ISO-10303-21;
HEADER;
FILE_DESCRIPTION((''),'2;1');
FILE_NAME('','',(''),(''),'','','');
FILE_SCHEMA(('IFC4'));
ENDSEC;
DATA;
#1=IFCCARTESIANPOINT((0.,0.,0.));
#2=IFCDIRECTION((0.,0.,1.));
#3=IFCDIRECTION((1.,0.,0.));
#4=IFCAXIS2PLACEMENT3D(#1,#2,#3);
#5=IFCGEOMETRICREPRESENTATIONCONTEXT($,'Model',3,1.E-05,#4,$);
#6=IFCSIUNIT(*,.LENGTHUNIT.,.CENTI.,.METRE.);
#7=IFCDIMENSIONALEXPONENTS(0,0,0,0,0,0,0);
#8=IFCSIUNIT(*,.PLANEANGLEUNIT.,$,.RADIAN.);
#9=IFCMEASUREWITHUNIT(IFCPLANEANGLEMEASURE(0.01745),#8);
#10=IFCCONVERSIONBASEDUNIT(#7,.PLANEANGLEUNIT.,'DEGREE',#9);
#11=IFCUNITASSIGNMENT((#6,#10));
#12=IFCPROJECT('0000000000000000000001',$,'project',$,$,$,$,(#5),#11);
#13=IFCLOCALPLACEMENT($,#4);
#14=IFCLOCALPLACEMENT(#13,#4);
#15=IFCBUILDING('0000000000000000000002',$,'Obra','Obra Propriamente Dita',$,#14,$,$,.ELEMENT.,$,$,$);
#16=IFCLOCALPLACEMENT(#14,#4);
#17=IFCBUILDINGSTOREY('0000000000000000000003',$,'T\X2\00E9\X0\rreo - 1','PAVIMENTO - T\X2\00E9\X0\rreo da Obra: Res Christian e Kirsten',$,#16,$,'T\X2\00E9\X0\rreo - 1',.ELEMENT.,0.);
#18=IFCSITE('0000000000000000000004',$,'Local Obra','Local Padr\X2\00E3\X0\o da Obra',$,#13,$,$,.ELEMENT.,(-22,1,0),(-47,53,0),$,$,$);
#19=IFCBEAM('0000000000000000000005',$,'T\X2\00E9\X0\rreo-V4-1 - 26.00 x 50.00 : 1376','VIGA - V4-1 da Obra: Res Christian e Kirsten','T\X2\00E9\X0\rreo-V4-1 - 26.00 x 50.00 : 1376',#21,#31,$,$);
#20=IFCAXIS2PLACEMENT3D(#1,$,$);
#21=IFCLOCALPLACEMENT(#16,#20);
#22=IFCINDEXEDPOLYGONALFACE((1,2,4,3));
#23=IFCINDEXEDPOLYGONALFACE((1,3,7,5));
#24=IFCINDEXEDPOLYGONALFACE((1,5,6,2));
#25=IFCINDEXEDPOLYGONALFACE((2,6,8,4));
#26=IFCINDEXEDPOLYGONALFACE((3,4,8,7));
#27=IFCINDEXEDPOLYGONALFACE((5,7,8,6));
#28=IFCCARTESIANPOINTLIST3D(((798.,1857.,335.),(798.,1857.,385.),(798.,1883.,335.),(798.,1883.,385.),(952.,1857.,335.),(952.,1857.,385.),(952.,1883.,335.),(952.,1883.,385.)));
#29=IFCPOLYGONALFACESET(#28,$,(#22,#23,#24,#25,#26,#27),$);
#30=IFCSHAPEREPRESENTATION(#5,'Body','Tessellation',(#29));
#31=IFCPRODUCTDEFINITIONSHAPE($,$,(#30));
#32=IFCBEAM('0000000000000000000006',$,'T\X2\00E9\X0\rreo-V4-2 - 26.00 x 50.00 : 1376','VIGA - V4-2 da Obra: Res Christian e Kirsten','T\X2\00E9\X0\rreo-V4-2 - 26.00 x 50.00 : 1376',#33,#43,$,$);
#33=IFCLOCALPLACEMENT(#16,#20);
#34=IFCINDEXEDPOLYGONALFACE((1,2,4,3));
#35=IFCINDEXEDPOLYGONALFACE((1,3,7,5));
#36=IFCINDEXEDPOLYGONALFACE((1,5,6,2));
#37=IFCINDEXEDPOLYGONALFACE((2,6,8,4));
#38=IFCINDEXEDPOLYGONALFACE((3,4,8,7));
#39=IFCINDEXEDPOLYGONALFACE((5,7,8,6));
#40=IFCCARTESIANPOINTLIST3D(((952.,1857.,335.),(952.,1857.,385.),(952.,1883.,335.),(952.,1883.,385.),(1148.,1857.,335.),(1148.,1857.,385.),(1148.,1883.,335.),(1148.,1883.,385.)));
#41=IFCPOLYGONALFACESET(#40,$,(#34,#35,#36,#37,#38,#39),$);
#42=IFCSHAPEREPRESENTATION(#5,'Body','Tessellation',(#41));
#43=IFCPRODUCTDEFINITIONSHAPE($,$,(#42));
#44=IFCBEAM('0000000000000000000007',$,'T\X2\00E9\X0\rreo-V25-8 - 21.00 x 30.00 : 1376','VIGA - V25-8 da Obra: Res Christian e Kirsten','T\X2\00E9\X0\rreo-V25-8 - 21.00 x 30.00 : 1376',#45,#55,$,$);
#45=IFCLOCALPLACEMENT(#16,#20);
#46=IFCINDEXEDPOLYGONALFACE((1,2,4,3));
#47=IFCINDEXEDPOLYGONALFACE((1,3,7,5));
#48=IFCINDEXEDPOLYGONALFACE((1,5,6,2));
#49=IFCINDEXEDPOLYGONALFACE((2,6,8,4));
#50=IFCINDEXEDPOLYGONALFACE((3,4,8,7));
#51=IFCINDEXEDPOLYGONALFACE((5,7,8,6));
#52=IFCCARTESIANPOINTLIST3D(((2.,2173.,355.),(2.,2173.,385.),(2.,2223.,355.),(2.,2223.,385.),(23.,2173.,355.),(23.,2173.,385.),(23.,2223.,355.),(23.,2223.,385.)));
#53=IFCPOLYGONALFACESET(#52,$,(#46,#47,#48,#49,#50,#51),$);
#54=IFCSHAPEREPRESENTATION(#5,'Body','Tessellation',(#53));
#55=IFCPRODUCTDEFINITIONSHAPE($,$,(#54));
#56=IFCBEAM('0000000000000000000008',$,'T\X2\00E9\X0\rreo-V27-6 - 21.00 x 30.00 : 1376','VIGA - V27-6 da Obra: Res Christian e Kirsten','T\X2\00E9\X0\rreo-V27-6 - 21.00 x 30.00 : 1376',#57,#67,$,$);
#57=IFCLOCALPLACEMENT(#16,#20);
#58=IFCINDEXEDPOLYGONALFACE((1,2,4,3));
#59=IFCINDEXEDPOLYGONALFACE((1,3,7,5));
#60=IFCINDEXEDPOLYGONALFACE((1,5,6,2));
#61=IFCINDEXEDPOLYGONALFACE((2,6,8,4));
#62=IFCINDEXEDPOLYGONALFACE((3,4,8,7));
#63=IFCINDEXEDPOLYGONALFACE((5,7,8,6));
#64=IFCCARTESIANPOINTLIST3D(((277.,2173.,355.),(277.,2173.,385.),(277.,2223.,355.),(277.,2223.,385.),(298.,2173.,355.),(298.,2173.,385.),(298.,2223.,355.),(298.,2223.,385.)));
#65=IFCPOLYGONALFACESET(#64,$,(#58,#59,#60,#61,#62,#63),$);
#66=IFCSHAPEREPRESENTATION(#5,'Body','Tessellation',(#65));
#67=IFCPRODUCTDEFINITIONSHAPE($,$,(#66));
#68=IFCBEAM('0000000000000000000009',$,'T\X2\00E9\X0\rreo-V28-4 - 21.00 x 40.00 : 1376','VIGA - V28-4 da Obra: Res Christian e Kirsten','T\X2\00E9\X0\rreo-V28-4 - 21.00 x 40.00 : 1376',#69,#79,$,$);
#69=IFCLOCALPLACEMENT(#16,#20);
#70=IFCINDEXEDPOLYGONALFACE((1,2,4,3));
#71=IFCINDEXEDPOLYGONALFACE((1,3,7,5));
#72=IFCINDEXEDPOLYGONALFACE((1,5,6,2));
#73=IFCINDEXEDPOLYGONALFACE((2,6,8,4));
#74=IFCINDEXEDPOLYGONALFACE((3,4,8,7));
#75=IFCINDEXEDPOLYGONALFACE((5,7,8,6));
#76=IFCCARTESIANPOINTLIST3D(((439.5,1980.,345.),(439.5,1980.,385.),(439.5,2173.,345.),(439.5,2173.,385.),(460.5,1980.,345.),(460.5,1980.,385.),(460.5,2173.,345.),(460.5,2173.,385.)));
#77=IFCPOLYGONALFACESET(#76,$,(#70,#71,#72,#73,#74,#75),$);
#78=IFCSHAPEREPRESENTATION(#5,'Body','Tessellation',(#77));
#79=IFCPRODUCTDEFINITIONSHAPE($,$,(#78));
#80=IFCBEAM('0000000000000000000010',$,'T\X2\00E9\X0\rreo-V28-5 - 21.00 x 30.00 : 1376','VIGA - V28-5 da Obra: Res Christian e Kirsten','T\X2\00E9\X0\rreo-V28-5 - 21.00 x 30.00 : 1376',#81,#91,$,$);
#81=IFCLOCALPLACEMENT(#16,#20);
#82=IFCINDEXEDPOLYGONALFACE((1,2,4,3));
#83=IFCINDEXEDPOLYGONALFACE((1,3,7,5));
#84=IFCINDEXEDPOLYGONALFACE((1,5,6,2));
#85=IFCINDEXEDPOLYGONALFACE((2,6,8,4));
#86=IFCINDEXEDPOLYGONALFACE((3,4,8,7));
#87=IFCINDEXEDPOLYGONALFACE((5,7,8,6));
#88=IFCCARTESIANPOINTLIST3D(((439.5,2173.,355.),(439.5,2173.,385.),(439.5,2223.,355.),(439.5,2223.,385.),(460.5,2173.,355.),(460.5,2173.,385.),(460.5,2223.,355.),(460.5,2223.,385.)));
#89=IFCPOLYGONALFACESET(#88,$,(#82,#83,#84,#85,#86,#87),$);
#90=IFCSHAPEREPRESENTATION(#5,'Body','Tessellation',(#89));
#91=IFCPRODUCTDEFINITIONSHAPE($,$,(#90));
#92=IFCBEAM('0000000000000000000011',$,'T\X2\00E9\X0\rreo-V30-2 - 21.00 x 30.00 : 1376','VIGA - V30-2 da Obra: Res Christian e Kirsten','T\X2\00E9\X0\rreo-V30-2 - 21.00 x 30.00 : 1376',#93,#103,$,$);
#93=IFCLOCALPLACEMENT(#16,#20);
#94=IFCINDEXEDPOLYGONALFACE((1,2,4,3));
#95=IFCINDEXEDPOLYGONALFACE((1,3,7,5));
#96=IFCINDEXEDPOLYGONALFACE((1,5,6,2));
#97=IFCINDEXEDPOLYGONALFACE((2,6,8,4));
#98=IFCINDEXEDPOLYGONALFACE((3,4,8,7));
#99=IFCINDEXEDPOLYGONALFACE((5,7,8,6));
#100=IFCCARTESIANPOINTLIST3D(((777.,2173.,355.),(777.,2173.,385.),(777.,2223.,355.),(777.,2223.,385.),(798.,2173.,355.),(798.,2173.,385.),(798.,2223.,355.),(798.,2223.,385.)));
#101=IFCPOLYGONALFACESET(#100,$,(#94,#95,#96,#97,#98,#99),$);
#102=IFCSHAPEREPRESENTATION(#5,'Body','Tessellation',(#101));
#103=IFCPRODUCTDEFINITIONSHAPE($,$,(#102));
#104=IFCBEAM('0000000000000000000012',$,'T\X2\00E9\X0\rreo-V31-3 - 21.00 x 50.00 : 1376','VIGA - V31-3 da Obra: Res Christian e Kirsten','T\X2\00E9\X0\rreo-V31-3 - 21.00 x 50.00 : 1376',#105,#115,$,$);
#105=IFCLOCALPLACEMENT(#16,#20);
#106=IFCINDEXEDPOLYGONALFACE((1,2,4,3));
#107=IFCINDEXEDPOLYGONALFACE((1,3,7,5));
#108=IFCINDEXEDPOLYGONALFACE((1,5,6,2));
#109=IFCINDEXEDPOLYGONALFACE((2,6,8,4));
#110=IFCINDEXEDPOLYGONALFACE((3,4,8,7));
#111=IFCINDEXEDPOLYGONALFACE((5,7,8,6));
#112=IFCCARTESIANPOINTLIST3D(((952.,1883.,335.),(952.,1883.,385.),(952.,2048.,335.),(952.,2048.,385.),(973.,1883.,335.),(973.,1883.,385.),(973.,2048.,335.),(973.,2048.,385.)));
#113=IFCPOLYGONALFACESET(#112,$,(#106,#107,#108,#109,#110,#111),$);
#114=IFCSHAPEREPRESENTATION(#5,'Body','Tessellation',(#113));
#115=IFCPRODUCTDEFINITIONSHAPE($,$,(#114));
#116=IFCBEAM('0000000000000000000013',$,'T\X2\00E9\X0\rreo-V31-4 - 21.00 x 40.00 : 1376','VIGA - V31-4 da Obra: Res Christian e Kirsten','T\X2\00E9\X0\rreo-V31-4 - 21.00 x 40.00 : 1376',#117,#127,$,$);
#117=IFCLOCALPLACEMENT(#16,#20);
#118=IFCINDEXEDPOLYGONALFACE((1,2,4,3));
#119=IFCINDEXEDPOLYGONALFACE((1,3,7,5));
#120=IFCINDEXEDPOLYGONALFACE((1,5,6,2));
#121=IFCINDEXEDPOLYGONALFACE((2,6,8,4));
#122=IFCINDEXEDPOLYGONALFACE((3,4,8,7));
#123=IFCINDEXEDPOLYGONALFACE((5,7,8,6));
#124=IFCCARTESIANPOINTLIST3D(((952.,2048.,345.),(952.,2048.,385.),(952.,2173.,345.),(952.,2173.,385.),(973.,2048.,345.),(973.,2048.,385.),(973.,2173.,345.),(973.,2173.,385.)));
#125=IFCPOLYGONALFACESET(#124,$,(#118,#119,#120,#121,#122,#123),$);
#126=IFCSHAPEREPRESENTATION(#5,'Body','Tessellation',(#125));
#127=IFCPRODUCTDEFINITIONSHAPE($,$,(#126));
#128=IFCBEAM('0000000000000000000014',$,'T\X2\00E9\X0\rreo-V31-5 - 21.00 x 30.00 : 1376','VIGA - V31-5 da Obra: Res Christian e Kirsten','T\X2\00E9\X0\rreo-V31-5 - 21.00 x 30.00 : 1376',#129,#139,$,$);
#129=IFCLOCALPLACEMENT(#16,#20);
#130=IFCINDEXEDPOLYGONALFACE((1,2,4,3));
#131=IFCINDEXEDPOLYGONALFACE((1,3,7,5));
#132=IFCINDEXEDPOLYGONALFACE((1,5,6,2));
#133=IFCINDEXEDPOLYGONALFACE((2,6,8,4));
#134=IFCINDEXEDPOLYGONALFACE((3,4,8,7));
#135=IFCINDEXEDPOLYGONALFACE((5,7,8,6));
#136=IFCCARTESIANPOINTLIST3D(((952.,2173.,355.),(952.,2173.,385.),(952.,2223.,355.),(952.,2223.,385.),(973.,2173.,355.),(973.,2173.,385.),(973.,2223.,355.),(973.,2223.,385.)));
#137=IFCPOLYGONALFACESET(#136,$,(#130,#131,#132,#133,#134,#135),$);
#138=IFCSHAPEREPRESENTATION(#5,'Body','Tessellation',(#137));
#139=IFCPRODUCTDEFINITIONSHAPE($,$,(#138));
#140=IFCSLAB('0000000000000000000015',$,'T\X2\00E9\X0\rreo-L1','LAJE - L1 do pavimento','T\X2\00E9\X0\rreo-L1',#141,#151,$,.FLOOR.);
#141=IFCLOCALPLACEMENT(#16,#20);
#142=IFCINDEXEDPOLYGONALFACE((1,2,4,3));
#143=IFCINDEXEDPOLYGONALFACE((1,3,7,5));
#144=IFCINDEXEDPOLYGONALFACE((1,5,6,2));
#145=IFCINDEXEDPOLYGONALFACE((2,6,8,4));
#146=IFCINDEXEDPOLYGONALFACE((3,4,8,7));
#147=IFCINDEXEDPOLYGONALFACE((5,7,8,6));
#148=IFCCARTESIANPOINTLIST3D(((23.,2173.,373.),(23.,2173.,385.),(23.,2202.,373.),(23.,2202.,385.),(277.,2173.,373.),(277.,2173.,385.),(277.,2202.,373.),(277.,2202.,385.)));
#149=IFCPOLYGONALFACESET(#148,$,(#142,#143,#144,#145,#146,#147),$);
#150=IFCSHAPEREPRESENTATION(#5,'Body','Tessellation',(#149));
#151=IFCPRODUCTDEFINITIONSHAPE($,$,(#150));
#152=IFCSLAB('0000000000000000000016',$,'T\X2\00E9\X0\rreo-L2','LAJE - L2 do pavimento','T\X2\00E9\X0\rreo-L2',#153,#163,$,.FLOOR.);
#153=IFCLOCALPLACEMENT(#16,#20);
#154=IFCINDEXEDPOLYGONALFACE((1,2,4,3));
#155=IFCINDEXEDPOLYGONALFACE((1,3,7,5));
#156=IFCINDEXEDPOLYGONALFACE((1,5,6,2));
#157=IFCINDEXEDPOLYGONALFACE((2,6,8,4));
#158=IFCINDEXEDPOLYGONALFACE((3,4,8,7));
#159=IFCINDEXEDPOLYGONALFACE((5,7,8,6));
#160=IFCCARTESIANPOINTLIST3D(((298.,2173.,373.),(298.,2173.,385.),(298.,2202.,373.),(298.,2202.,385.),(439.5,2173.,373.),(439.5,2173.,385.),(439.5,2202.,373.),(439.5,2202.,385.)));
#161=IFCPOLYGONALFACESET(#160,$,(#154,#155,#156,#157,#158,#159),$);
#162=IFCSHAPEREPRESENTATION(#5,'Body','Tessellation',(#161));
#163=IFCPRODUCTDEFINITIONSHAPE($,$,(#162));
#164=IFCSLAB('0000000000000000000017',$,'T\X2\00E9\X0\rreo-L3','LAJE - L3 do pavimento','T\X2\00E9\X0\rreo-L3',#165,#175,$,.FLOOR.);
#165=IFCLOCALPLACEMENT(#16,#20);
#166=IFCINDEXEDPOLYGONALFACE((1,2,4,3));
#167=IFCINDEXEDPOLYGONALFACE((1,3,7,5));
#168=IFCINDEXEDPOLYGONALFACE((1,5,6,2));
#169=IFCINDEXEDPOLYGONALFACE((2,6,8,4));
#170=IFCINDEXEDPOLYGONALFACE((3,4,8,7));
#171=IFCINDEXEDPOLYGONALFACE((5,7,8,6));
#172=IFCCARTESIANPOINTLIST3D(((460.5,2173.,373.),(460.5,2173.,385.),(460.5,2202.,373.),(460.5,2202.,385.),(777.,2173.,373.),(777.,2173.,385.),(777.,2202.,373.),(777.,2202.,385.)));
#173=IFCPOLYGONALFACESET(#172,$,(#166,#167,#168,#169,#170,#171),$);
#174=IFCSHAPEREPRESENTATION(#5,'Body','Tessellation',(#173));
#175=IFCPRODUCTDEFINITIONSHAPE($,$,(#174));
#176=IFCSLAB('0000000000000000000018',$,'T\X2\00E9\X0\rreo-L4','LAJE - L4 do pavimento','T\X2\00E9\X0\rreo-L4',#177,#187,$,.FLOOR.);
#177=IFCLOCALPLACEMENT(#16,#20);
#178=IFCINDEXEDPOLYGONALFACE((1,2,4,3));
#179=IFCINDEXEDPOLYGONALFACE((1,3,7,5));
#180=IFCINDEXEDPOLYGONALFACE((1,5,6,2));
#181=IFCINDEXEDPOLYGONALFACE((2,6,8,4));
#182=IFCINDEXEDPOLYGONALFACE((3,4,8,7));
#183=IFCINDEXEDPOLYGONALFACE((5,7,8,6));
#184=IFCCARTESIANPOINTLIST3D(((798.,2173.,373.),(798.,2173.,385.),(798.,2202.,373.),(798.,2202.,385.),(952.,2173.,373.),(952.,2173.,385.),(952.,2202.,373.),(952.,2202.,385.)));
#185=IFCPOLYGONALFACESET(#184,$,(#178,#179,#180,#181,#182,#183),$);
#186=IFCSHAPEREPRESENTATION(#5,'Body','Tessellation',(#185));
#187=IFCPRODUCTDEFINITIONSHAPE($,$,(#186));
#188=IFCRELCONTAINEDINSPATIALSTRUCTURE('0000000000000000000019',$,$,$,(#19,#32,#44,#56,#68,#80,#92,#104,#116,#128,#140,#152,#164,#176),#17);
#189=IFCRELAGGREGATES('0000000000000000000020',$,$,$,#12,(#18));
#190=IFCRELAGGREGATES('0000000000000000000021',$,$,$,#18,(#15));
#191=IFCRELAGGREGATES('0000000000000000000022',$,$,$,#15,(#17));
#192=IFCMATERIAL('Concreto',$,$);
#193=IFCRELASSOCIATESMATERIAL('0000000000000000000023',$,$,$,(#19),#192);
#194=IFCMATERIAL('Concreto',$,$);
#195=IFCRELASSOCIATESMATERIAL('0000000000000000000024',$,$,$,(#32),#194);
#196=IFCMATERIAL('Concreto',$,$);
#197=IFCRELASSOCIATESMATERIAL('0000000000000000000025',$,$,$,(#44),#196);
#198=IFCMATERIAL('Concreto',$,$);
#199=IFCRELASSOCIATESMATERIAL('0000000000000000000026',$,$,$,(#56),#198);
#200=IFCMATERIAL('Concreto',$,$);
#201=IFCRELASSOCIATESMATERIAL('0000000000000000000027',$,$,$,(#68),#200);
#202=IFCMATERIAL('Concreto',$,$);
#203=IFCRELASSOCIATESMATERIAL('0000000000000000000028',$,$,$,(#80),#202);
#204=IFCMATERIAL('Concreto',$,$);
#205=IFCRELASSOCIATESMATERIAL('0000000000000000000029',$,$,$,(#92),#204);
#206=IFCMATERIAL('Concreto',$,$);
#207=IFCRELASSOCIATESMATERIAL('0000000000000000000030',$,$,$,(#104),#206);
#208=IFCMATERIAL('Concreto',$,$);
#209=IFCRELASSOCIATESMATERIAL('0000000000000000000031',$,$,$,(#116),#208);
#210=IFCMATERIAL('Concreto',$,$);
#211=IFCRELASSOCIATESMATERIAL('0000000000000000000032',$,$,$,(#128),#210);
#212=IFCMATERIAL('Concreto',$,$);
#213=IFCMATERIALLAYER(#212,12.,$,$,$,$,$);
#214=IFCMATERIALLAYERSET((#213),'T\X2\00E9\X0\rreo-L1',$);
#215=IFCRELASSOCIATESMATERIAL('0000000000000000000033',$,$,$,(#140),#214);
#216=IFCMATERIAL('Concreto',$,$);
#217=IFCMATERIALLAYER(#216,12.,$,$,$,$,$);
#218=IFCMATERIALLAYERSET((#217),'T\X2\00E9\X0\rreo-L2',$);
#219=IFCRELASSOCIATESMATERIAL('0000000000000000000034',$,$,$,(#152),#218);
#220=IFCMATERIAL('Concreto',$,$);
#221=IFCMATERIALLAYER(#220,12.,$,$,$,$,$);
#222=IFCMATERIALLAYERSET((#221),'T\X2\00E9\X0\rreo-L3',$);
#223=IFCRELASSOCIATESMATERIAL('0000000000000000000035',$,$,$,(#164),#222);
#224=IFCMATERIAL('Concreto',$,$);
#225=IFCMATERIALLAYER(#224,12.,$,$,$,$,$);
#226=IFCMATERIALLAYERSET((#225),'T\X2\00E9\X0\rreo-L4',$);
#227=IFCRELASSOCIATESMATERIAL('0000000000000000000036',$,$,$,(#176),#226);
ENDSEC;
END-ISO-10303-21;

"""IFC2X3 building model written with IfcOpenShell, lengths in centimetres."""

from ifc_helpers import new_model, entity, si_unit, converted_unit, frame, origin_with_axes, place, context, project, spatial, polyline, outline, extrude, material, layer, layer_set, layer_usage, element, save


model = new_model("IFC2X3")

# Units and contexts
model_context = context("Model", 3, precision=1e-05, world=origin_with_axes())
ifc_project = project(units=[si_unit("LENGTHUNIT", "METRE", prefix="CENTI"), converted_unit("PLANEANGLEUNIT", "DEGREE", entity("IfcPlaneAngleMeasure", 0.01745), si_unit("PLANEANGLEUNIT", "RADIAN"), dimensions=[0, 0, 0, 0, 0, 0, 0])], contexts=[model_context])

# Site, building, storey
site_placement = place(None, origin_with_axes())
site = spatial("IfcSite", under=ifc_project, at=site_placement, Name="Local Obra", Description="Local Padrão da Obra", CompositionType="ELEMENT", RefLatitude=(-22, 1, 0), RefLongitude=(-47, 53, 0))
building_placement = place(site_placement, origin_with_axes())
building = spatial("IfcBuilding", under=site, at=building_placement, Name="Obra", Description="Obra Propriamente Dita", CompositionType="ELEMENT")
storey_placement = place(building_placement, origin_with_axes())
storey = spatial("IfcBuildingStorey", under=building, at=storey_placement, Name="Térreo - 1", Description="PAVIMENTO - Térreo da Obra: Res Christian e Kirsten", LongName="Térreo - 1", CompositionType="ELEMENT", Elevation=0.0)

# Beams
ifc_material_1 = material(Name="Concreto")
beam_1_placement = place(storey_placement, frame((798.0, 1883.0, 385.0), z_axis=(1.0, 0.0, 0.0), x_axis=(0.0, -1.0, 0.0)))
element("IfcBeam", 1, at=beam_1_placement, inside=storey, material=ifc_material_1, Name="Térreo-V4-1 - 26.00 x 50.00 : 1376", Description="VIGA - V4-1 da Obra: Res Christian e Kirsten", ObjectType="Térreo-V4-1 - 26.00 x 50.00 : 1376", context=model_context, shape_type="SweptSolid", body=[
    extrude(outline(polyline([(0.0, 0.0), (26.0, 0.0), (26.0, 50.0), (0.0, 50.0), (0.0, 0.0)])), origin_with_axes(), (0.0, 0.0, 1.0), 154.0),
])
ifc_material_2 = material(Name="Concreto")
beam_2_placement = place(storey_placement, frame((952.0, 1883.0, 385.0), z_axis=(1.0, 0.0, 0.0), x_axis=(0.0, -1.0, 0.0)))
element("IfcBeam", 2, at=beam_2_placement, inside=storey, material=ifc_material_2, Name="Térreo-V4-2 - 26.00 x 50.00 : 1376", Description="VIGA - V4-2 da Obra: Res Christian e Kirsten", ObjectType="Térreo-V4-2 - 26.00 x 50.00 : 1376", context=model_context, shape_type="SweptSolid", body=[
    extrude(outline(polyline([(0.0, 0.0), (26.0, 0.0), (26.0, 50.0), (0.0, 50.0), (0.0, 0.0)])), origin_with_axes(), (0.0, 0.0, 1.0), 196.0),
])
ifc_material_3 = material(Name="Concreto")
beam_3_placement = place(storey_placement, frame((2.0, 2173.0, 385.0), z_axis=(0.0, 1.0, 0.0), x_axis=(1.0, 0.0, 0.0)))
element("IfcBeam", 3, at=beam_3_placement, inside=storey, material=ifc_material_3, Name="Térreo-V25-8 - 21.00 x 30.00 : 1376", Description="VIGA - V25-8 da Obra: Res Christian e Kirsten", ObjectType="Térreo-V25-8 - 21.00 x 30.00 : 1376", context=model_context, shape_type="SweptSolid", body=[
    extrude(outline(polyline([(0.0, 0.0), (21.0, 0.0), (21.0, 30.0), (0.0, 30.0), (0.0, 0.0)])), origin_with_axes(), (0.0, 0.0, 1.0), 50.0),
])
ifc_material_4 = material(Name="Concreto")
beam_4_placement = place(storey_placement, frame((277.0, 2173.0, 385.0), z_axis=(0.0, 1.0, 0.0), x_axis=(1.0, 0.0, 0.0)))
element("IfcBeam", 4, at=beam_4_placement, inside=storey, material=ifc_material_4, Name="Térreo-V27-6 - 21.00 x 30.00 : 1376", Description="VIGA - V27-6 da Obra: Res Christian e Kirsten", ObjectType="Térreo-V27-6 - 21.00 x 30.00 : 1376", context=model_context, shape_type="SweptSolid", body=[
    extrude(outline(polyline([(0.0, 0.0), (21.0, 0.0), (21.0, 30.0), (0.0, 30.0), (0.0, 0.0)])), origin_with_axes(), (0.0, 0.0, 1.0), 50.0),
])
ifc_material_5 = material(Name="Concreto")
beam_5_placement = place(storey_placement, frame((450.0, 1980.0, 385.0), z_axis=(0.0, 1.0, 0.0), x_axis=(1.0, 0.0, 0.0)))
element("IfcBeam", 5, at=beam_5_placement, inside=storey, material=ifc_material_5, Name="Térreo-V28-4 - 21.00 x 40.00 : 1376", Description="VIGA - V28-4 da Obra: Res Christian e Kirsten", ObjectType="Térreo-V28-4 - 21.00 x 40.00 : 1376", context=model_context, shape_type="SweptSolid", body=[
    extrude(outline(polyline([(-10.5, 0.0), (10.5, 0.0), (10.5, 40.0), (-10.5, 40.0), (-10.5, 0.0)])), origin_with_axes(), (0.0, 0.0, 1.0), 193.0),
])
ifc_material_6 = material(Name="Concreto")
beam_6_placement = place(storey_placement, frame((450.0, 2173.0, 385.0), z_axis=(0.0, 1.0, 0.0), x_axis=(1.0, 0.0, 0.0)))
element("IfcBeam", 6, at=beam_6_placement, inside=storey, material=ifc_material_6, Name="Térreo-V28-5 - 21.00 x 30.00 : 1376", Description="VIGA - V28-5 da Obra: Res Christian e Kirsten", ObjectType="Térreo-V28-5 - 21.00 x 30.00 : 1376", context=model_context, shape_type="SweptSolid", body=[
    extrude(outline(polyline([(-10.5, 0.0), (10.5, 0.0), (10.5, 30.0), (-10.5, 30.0), (-10.5, 0.0)])), origin_with_axes(), (0.0, 0.0, 1.0), 50.0),
])
ifc_material_7 = material(Name="Concreto")
beam_7_placement = place(storey_placement, frame((787.5, 2173.0, 385.0), z_axis=(0.0, 1.0, 0.0), x_axis=(1.0, 0.0, 0.0)))
element("IfcBeam", 7, at=beam_7_placement, inside=storey, material=ifc_material_7, Name="Térreo-V30-2 - 21.00 x 30.00 : 1376", Description="VIGA - V30-2 da Obra: Res Christian e Kirsten", ObjectType="Térreo-V30-2 - 21.00 x 30.00 : 1376", context=model_context, shape_type="SweptSolid", body=[
    extrude(outline(polyline([(-10.5, 0.0), (10.5, 0.0), (10.5, 30.0), (-10.5, 30.0), (-10.5, 0.0)])), origin_with_axes(), (0.0, 0.0, 1.0), 50.0),
])
ifc_material_8 = material(Name="Concreto")
beam_8_placement = place(storey_placement, frame((952.0, 1883.0, 385.0), z_axis=(0.0, 1.0, 0.0), x_axis=(1.0, 0.0, 0.0)))
element("IfcBeam", 8, at=beam_8_placement, inside=storey, material=ifc_material_8, Name="Térreo-V31-3 - 21.00 x 50.00 : 1376", Description="VIGA - V31-3 da Obra: Res Christian e Kirsten", ObjectType="Térreo-V31-3 - 21.00 x 50.00 : 1376", context=model_context, shape_type="SweptSolid", body=[
    extrude(outline(polyline([(0.0, 0.0), (21.0, 0.0), (21.0, 50.0), (0.0, 50.0), (0.0, 0.0)])), origin_with_axes(), (0.0, 0.0, 1.0), 165.0),
])
ifc_material_9 = material(Name="Concreto")
beam_9_placement = place(storey_placement, frame((952.0, 2048.0, 385.0), z_axis=(0.0, 1.0, 0.0), x_axis=(1.0, 0.0, 0.0)))
element("IfcBeam", 9, at=beam_9_placement, inside=storey, material=ifc_material_9, Name="Térreo-V31-4 - 21.00 x 40.00 : 1376", Description="VIGA - V31-4 da Obra: Res Christian e Kirsten", ObjectType="Térreo-V31-4 - 21.00 x 40.00 : 1376", context=model_context, shape_type="SweptSolid", body=[
    extrude(outline(polyline([(0.0, 0.0), (21.0, 0.0), (21.0, 40.0), (0.0, 40.0), (0.0, 0.0)])), origin_with_axes(), (0.0, 0.0, 1.0), 125.0),
])
ifc_material_10 = material(Name="Concreto")
beam_10_placement = place(storey_placement, frame((952.0, 2173.0, 385.0), z_axis=(0.0, 1.0, 0.0), x_axis=(1.0, 0.0, 0.0)))
element("IfcBeam", 10, at=beam_10_placement, inside=storey, material=ifc_material_10, Name="Térreo-V31-5 - 21.00 x 30.00 : 1376", Description="VIGA - V31-5 da Obra: Res Christian e Kirsten", ObjectType="Térreo-V31-5 - 21.00 x 30.00 : 1376", context=model_context, shape_type="SweptSolid", body=[
    extrude(outline(polyline([(0.0, 0.0), (21.0, 0.0), (21.0, 30.0), (0.0, 30.0), (0.0, 0.0)])), origin_with_axes(), (0.0, 0.0, 1.0), 50.0),
])

# Slabs
ifc_material_11 = material(Name="Concreto")
ifc_layer_1 = layer(ifc_material_11, 12.0)
ifc_layer_set_1 = layer_set([ifc_layer_1], Name="Térreo-L1")
ifc_layer_usage_1 = layer_usage(ifc_layer_set_1, "AXIS3", "POSITIVE", 0.0)
slab_1_placement = place(storey_placement, frame((277.0, 2173.0, 373.0), z_axis=(0.0, 0.0, 1.0), x_axis=(1.0, 0.0, 0.0)))
element("IfcSlab", 11, at=slab_1_placement, inside=storey, material=ifc_layer_usage_1, Name="Térreo-L1", Description="LAJE - L1 do pavimento", ObjectType="Térreo-L1", PredefinedType="FLOOR", context=model_context, shape_type="SweptSolid", body=[
    extrude(outline(polyline([(0.0, 29.0), (-254.0, 29.0), (-254.0, 0.0), (0.0, 0.0), (0.0, 29.0)])), origin_with_axes(), (0.0, 0.0, 1.0), 12.0),
])
ifc_material_12 = material(Name="Concreto")
ifc_layer_2 = layer(ifc_material_12, 12.0)
ifc_layer_set_2 = layer_set([ifc_layer_2], Name="Térreo-L2")
ifc_layer_usage_2 = layer_usage(ifc_layer_set_2, "AXIS3", "POSITIVE", 0.0)
slab_2_placement = place(storey_placement, frame((439.5, 2173.0, 373.0), z_axis=(0.0, 0.0, 1.0), x_axis=(1.0, 0.0, 0.0)))
element("IfcSlab", 12, at=slab_2_placement, inside=storey, material=ifc_layer_usage_2, Name="Térreo-L2", Description="LAJE - L2 do pavimento", ObjectType="Térreo-L2", PredefinedType="FLOOR", context=model_context, shape_type="SweptSolid", body=[
    extrude(outline(polyline([(0.0, 29.0), (-141.5, 29.0), (-141.5, 0.0), (0.0, 0.0), (0.0, 29.0)])), origin_with_axes(), (0.0, 0.0, 1.0), 12.0),
])
ifc_material_13 = material(Name="Concreto")
ifc_layer_3 = layer(ifc_material_13, 12.0)
ifc_layer_set_3 = layer_set([ifc_layer_3], Name="Térreo-L3")
ifc_layer_usage_3 = layer_usage(ifc_layer_set_3, "AXIS3", "POSITIVE", 0.0)
slab_3_placement = place(storey_placement, frame((777.0, 2173.0, 373.0), z_axis=(0.0, 0.0, 1.0), x_axis=(1.0, 0.0, 0.0)))
element("IfcSlab", 13, at=slab_3_placement, inside=storey, material=ifc_layer_usage_3, Name="Térreo-L3", Description="LAJE - L3 do pavimento", ObjectType="Térreo-L3", PredefinedType="FLOOR", context=model_context, shape_type="SweptSolid", body=[
    extrude(outline(polyline([(0.0, 29.0), (-316.5, 29.0), (-316.5, 0.0), (0.0, 0.0), (0.0, 29.0)])), origin_with_axes(), (0.0, 0.0, 1.0), 12.0),
])
ifc_material_14 = material(Name="Concreto")
ifc_layer_4 = layer(ifc_material_14, 12.0)
ifc_layer_set_4 = layer_set([ifc_layer_4], Name="Térreo-L4")
ifc_layer_usage_4 = layer_usage(ifc_layer_set_4, "AXIS3", "POSITIVE", 0.0)
slab_4_placement = place(storey_placement, frame((952.0, 2173.0, 373.0), z_axis=(0.0, 0.0, 1.0), x_axis=(1.0, 0.0, 0.0)))
element("IfcSlab", 14, at=slab_4_placement, inside=storey, material=ifc_layer_usage_4, Name="Térreo-L4", Description="LAJE - L4 do pavimento", ObjectType="Térreo-L4", PredefinedType="FLOOR", context=model_context, shape_type="SweptSolid", body=[
    extrude(outline(polyline([(0.0, 29.0), (-154.0, 29.0), (-154.0, 0.0), (0.0, 0.0), (0.0, 29.0)])), origin_with_axes(), (0.0, 0.0, 1.0), 12.0),
])

save(model, "model.ifc")
